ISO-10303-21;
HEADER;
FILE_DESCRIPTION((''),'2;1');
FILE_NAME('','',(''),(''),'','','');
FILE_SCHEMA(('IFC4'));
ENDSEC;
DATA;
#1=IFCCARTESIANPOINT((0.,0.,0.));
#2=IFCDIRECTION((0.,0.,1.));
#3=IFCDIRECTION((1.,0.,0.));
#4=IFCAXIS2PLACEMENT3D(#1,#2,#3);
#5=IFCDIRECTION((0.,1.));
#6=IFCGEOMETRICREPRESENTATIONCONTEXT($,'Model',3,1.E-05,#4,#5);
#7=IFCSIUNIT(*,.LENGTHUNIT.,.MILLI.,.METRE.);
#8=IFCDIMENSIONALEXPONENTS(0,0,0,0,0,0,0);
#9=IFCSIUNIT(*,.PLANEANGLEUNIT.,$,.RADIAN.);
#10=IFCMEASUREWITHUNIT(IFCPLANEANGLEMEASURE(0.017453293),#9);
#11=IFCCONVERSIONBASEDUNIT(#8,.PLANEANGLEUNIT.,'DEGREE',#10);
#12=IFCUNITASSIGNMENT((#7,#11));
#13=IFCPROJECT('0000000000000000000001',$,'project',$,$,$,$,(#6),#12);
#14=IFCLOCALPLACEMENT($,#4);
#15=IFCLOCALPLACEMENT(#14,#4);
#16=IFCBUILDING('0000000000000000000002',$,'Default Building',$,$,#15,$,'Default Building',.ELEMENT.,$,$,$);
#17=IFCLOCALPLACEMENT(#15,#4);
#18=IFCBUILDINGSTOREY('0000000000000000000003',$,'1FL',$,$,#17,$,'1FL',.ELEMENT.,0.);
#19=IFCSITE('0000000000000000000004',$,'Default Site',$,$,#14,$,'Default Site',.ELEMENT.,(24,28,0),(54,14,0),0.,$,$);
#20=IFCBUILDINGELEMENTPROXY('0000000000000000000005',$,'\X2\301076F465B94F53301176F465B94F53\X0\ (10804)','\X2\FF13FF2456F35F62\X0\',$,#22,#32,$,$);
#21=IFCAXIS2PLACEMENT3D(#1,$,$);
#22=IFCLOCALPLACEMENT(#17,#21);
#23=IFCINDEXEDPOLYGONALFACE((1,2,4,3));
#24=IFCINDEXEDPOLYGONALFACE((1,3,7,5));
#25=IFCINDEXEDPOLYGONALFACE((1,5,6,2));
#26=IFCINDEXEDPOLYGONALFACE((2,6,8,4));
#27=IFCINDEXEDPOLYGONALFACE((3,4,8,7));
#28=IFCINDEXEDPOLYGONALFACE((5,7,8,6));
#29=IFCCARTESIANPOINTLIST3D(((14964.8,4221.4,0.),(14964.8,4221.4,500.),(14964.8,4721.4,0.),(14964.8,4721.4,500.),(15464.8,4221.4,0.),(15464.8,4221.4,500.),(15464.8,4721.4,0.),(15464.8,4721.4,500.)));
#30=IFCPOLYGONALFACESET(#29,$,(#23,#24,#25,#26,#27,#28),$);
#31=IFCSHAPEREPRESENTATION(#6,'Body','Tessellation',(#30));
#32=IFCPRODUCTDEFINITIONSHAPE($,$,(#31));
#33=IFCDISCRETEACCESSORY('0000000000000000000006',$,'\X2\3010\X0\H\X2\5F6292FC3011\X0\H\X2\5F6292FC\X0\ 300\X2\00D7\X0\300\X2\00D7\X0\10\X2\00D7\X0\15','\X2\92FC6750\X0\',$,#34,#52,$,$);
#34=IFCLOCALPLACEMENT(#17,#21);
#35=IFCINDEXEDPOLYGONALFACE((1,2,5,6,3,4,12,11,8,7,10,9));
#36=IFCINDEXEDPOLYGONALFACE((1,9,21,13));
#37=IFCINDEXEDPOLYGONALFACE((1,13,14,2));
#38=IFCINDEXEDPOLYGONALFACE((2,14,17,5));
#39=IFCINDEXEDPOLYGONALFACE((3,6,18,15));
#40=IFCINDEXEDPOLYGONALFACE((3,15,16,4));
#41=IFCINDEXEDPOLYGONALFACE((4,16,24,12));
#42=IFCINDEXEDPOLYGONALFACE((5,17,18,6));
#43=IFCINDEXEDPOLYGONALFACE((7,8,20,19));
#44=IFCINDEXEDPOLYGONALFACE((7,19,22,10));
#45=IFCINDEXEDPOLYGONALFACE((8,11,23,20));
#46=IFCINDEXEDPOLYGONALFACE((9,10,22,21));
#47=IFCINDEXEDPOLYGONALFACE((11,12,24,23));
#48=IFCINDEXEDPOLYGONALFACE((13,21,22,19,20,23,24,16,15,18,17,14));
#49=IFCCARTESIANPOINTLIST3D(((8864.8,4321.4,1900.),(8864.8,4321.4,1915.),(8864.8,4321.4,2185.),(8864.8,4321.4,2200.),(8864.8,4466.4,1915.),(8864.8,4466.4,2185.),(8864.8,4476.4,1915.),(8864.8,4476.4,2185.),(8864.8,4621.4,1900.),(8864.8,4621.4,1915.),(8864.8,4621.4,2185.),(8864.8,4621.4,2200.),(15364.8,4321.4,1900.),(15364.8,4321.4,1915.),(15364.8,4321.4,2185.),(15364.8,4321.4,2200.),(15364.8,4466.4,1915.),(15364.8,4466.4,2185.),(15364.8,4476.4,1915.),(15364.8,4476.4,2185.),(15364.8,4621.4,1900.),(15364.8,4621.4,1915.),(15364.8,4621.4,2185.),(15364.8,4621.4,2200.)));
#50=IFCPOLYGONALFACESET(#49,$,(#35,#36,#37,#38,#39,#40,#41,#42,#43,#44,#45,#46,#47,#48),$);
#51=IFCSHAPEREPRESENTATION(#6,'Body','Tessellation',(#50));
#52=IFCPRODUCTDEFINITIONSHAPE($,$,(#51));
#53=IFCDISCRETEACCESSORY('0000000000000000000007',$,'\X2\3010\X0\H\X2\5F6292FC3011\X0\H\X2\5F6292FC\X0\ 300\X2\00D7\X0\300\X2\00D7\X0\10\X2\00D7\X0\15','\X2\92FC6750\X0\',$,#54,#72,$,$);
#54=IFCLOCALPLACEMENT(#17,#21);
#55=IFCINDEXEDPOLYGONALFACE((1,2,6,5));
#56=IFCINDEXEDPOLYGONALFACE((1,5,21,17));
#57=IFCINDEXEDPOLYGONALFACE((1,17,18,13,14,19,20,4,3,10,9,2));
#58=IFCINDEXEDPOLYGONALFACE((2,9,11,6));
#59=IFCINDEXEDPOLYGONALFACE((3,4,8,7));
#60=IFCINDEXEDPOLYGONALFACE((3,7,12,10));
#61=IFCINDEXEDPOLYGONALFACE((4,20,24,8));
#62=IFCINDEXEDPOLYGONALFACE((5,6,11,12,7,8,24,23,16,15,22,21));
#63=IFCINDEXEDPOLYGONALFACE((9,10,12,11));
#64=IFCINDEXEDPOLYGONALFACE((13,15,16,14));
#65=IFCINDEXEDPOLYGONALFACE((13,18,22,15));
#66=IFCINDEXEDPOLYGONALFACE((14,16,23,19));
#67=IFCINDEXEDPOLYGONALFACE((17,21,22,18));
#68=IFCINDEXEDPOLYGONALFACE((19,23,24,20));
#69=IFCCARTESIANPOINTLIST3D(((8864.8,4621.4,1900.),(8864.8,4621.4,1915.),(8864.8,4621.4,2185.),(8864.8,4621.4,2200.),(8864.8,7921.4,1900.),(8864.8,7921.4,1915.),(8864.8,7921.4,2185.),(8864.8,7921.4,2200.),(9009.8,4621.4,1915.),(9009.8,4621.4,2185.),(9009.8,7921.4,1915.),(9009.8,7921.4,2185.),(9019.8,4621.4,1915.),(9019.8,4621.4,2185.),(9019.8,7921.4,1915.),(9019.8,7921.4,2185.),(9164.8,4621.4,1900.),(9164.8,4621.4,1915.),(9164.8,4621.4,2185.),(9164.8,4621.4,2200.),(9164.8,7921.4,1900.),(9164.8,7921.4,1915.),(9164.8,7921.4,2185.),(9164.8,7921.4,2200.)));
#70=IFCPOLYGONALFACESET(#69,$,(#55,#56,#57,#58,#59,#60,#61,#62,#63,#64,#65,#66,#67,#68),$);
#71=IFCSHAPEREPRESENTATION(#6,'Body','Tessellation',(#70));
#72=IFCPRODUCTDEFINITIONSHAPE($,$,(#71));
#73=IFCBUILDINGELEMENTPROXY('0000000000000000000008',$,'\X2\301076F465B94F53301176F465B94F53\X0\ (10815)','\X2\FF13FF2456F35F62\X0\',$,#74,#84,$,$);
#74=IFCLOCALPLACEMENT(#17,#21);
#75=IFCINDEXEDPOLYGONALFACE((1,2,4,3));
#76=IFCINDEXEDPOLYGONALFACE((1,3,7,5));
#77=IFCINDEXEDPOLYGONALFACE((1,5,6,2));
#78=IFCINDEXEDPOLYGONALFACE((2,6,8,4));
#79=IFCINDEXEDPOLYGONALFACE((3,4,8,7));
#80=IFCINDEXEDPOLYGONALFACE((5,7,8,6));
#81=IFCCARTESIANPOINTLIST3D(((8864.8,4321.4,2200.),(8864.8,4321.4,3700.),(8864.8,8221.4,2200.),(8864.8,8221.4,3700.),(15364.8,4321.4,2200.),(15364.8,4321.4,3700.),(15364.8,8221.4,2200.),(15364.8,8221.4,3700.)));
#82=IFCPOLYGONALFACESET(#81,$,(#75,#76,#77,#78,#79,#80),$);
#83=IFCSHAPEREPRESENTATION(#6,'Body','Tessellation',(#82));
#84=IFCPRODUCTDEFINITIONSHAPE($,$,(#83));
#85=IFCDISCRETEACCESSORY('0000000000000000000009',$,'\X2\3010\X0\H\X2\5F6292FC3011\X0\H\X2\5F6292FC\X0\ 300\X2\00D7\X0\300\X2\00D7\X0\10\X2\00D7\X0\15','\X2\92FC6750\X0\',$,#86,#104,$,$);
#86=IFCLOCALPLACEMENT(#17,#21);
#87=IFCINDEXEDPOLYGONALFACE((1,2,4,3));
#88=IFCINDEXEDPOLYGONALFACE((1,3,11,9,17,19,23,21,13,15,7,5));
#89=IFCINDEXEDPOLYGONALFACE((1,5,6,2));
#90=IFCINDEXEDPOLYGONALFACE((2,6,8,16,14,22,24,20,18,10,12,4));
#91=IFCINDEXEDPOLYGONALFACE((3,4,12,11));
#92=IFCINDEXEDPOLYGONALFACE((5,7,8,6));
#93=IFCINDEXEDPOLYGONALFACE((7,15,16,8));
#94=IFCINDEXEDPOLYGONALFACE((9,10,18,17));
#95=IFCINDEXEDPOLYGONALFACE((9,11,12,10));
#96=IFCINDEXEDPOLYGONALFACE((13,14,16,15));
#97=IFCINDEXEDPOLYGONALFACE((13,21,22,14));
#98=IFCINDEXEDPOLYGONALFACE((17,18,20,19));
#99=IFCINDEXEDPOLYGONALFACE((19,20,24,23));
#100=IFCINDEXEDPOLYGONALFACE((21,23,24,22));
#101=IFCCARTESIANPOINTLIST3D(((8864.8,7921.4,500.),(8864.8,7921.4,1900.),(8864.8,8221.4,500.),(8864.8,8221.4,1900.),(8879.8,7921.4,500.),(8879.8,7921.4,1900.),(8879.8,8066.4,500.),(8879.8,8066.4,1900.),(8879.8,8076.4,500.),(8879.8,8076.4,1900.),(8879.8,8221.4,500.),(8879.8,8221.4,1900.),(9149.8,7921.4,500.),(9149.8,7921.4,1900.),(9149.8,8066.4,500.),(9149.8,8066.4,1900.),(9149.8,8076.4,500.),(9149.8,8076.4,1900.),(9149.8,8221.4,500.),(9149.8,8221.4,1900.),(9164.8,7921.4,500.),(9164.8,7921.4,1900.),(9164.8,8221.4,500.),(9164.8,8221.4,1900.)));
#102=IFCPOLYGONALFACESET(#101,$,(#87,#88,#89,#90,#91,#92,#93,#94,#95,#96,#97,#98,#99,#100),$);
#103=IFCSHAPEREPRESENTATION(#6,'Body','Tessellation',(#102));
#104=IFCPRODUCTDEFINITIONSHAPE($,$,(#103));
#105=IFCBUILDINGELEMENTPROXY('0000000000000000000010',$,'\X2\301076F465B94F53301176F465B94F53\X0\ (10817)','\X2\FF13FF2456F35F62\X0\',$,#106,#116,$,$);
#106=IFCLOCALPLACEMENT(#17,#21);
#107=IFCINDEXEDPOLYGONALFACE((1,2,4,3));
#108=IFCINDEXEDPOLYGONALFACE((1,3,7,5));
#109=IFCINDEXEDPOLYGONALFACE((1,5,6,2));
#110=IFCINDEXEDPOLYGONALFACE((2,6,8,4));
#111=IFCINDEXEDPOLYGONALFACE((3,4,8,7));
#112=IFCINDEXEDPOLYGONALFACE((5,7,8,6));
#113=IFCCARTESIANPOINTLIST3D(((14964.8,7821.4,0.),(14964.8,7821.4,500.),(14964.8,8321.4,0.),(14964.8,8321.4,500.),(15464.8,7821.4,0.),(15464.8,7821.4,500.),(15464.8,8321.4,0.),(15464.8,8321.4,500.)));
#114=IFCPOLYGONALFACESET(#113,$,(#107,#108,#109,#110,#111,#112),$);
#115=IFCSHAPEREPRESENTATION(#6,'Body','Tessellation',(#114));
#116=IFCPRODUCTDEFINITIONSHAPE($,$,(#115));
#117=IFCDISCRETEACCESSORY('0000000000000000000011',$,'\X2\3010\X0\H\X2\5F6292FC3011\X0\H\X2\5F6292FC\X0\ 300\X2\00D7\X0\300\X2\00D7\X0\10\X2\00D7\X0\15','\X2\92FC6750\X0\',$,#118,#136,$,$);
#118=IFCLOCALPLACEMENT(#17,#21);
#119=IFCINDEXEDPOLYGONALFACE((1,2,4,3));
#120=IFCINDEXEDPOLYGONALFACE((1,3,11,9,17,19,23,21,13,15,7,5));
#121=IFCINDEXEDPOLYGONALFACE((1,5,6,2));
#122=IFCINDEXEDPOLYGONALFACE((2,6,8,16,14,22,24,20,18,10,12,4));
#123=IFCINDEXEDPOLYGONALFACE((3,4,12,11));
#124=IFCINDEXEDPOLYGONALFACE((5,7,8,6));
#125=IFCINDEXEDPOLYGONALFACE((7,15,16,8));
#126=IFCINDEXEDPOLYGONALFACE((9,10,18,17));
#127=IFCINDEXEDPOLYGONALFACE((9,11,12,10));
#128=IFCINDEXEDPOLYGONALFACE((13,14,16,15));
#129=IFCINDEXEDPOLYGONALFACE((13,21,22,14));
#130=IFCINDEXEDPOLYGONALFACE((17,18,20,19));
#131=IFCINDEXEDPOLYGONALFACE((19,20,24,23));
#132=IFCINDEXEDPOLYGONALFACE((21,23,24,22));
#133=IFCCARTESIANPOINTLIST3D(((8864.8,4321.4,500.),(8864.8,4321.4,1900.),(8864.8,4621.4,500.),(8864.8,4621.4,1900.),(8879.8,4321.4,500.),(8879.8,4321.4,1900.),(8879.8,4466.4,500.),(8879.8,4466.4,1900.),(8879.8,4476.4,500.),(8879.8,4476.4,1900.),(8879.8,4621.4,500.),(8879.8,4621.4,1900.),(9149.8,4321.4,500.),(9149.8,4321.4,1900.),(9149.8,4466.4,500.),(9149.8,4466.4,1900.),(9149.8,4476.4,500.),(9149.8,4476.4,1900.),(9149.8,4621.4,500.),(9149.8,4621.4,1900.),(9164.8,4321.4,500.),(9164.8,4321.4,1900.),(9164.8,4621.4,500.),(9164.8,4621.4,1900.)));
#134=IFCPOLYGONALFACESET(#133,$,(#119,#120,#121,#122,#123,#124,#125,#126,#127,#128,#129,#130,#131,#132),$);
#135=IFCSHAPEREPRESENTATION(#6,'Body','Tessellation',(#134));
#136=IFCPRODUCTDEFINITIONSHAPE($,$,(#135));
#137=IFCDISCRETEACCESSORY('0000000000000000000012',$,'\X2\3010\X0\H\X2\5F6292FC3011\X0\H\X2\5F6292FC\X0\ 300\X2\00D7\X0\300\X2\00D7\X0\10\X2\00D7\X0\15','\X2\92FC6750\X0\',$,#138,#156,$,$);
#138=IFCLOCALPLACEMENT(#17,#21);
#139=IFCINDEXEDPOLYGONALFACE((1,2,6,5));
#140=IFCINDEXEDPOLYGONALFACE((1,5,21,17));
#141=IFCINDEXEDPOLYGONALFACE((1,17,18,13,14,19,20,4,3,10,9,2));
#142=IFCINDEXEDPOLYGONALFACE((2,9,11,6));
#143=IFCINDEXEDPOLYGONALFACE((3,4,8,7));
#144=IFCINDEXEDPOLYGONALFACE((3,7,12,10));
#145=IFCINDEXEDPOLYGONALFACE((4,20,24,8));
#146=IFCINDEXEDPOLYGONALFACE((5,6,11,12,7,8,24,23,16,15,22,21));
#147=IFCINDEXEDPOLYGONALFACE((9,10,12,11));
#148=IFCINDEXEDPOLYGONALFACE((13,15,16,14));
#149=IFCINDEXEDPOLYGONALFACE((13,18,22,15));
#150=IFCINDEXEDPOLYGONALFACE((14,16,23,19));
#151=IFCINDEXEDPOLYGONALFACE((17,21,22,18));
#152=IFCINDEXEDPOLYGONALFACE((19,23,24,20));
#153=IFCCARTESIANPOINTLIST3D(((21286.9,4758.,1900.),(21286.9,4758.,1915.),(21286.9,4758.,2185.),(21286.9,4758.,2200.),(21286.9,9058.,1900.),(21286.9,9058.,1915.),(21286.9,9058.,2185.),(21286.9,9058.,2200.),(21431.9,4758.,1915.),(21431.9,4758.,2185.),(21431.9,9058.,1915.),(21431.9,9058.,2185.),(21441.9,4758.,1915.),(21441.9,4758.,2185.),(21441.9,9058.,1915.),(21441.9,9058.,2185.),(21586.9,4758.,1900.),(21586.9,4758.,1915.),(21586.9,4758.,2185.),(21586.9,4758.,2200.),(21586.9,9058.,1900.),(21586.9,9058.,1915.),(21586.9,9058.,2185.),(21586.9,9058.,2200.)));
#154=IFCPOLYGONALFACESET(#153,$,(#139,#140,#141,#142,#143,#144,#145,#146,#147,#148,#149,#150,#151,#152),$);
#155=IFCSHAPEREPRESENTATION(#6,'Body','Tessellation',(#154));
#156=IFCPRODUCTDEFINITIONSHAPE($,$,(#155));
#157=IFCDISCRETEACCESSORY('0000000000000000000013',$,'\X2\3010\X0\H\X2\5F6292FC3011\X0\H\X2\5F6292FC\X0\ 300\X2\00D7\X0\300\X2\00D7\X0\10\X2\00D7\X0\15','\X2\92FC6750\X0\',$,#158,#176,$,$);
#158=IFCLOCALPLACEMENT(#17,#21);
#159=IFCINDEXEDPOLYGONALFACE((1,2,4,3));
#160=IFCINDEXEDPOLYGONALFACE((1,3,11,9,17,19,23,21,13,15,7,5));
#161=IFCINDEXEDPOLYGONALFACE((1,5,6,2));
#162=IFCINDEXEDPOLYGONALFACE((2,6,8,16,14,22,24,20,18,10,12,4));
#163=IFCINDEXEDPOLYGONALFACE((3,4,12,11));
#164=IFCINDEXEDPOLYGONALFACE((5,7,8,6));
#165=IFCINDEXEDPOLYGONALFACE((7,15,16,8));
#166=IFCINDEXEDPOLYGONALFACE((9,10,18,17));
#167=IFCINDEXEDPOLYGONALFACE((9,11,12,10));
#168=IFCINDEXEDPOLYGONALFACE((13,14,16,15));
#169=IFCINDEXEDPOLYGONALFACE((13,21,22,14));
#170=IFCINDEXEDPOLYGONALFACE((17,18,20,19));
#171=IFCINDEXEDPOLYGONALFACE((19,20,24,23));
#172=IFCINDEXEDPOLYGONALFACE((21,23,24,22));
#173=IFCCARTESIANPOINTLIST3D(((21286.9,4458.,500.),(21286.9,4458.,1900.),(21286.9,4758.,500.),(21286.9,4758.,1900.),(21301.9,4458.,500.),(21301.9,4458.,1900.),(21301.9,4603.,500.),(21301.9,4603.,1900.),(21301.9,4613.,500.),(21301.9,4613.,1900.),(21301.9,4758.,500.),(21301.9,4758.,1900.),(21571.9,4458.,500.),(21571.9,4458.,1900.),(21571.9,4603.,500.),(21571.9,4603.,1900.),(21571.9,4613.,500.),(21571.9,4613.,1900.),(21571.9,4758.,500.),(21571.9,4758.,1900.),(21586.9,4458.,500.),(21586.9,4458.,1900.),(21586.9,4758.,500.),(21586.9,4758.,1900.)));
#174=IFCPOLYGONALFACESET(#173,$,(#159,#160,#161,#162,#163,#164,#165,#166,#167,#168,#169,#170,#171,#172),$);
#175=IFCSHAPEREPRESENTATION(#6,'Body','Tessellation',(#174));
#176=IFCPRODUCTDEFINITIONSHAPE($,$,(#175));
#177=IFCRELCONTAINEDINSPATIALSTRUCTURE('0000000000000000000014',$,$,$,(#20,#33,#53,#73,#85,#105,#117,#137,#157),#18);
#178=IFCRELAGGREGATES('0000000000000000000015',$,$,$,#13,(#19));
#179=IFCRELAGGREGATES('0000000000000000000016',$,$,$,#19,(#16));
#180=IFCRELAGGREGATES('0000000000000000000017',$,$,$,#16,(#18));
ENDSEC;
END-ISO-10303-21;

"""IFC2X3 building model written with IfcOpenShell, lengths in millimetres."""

from ifc_helpers import new_model, entity, si_unit, converted_unit, direction, frame, origin_with_axes, origin_2d_with_axis, place, context, project, spatial, rectangle, i_section, extrude, source, transform, mapped, element, save


model = new_model("IFC2X3")

# Units and contexts
model_context = context("Model", 3, precision=1e-05, world=origin_with_axes(), true_north=direction((0.0, 1.0)))
ifc_project = project(units=[si_unit("LENGTHUNIT", "METRE", prefix="MILLI"), converted_unit("PLANEANGLEUNIT", "DEGREE", entity("IfcPlaneAngleMeasure", 0.017453293), si_unit("PLANEANGLEUNIT", "RADIAN"), dimensions=[0, 0, 0, 0, 0, 0, 0])], contexts=[model_context])

# Site, building, storey
site_placement = place(None, origin_with_axes())
site = spatial("IfcSite", under=ifc_project, at=site_placement, Name="Default Site", LongName="Default Site", CompositionType="ELEMENT", RefLatitude=(24, 28, 0), RefLongitude=(54, 14, 0), RefElevation=0.0)
building_placement = place(site_placement, origin_with_axes())
building = spatial("IfcBuilding", under=site, at=building_placement, Name="Default Building", LongName="Default Building", CompositionType="ELEMENT")
storey_placement = place(building_placement, origin_with_axes())
storey = spatial("IfcBuildingStorey", under=building, at=storey_placement, Name="1FL", LongName="1FL", CompositionType="ELEMENT", Elevation=0.0)

# Building element proxy
shared_shape_1 = source(origin_with_axes(), model_context, "Body", "SweptSolid", [
    extrude(rectangle(XDim=500.0, YDim=500.0, at=origin_2d_with_axis()), origin_with_axes(), (0.0, 0.0, 1.0), 500.0),
])
proxy_1_placement = place(storey_placement, frame((15214.8, 4471.4, 0.0), z_axis=(0.0, 0.0, 1.0), x_axis=(1.0, 0.0, 0.0)))
element("IfcBuildingElementProxy", 1, at=proxy_1_placement, inside=storey, Name="【直方体】直方体 (10804)", Description="３Ｄ図形", context=model_context, shape_type="MappedRepresentation", body=[
    mapped(shared_shape_1, transform((0.0, 0.0, 0.0))),
])

# Discrete accessories
shared_shape_2 = source(origin_with_axes(), model_context, "Body", "SweptSolid", [
    extrude(i_section(OverallWidth=300.0, OverallDepth=300.0, WebThickness=10.0, FlangeThickness=15.0, at=origin_2d_with_axis()), frame((3250.0, 0.0, -150.0), z_axis=(-1.0, 0.0, 0.0), x_axis=(0.0, -1.0, 0.0)), (0.0, 0.0, 1.0), 6500.0),
])
discrete_accessory_1_placement = place(storey_placement, frame((12114.8, 4471.4, 2200.0), z_axis=(0.0, 0.0, 1.0), x_axis=(1.0, 0.0, 0.0)))
element("IfcDiscreteAccessory", 2, at=discrete_accessory_1_placement, inside=storey, Name="【H形鋼】H形鋼 300×300×10×15", Description="鋼材", context=model_context, shape_type="MappedRepresentation", body=[
    mapped(shared_shape_2, transform((0.0, 0.0, 0.0))),
])
shared_shape_3 = source(origin_with_axes(), model_context, "Body", "SweptSolid", [
    extrude(i_section(OverallWidth=300.0, OverallDepth=300.0, WebThickness=10.0, FlangeThickness=15.0, at=origin_2d_with_axis()), frame((1650.0, 0.0, -150.0), z_axis=(-1.0, 0.0, 0.0), x_axis=(0.0, -1.0, 0.0)), (0.0, 0.0, 1.0), 3300.0),
])
discrete_accessory_2_placement = place(storey_placement, frame((9014.8, 6271.4, 2200.0), z_axis=(0.0, 0.0, 1.0), x_axis=(0.0, -1.0, 0.0)))
element("IfcDiscreteAccessory", 3, at=discrete_accessory_2_placement, inside=storey, Name="【H形鋼】H形鋼 300×300×10×15", Description="鋼材", context=model_context, shape_type="MappedRepresentation", body=[
    mapped(shared_shape_3, transform((0.0, 0.0, 0.0))),
])

# Building element proxy
shared_shape_4 = source(origin_with_axes(), model_context, "Body", "SweptSolid", [
    extrude(rectangle(XDim=6500.0, YDim=3900.0, at=origin_2d_with_axis()), origin_with_axes(), (0.0, 0.0, 1.0), 1500.0),
])
proxy_2_placement = place(storey_placement, frame((12114.8, 6271.4, 2200.0), z_axis=(0.0, 0.0, 1.0), x_axis=(1.0, 0.0, 0.0)))
element("IfcBuildingElementProxy", 4, at=proxy_2_placement, inside=storey, Name="【直方体】直方体 (10815)", Description="３Ｄ図形", context=model_context, shape_type="MappedRepresentation", body=[
    mapped(shared_shape_4, transform((0.0, 0.0, 0.0))),
])

# Discrete accessory
shared_shape_5 = source(origin_with_axes(), model_context, "Body", "SweptSolid", [
    extrude(i_section(OverallWidth=300.0, OverallDepth=300.0, WebThickness=10.0, FlangeThickness=15.0, at=origin_2d_with_axis()), frame((700.0, 0.0, -150.0), z_axis=(-1.0, 0.0, 0.0), x_axis=(0.0, -1.0, 0.0)), (0.0, 0.0, 1.0), 1400.0),
])
discrete_accessory_3_placement = place(storey_placement, frame((8864.8, 8071.4, 1200.0), z_axis=(-1.0, 0.0, 0.0), x_axis=(0.0, 0.0, 1.0)))
element("IfcDiscreteAccessory", 5, at=discrete_accessory_3_placement, inside=storey, Name="【H形鋼】H形鋼 300×300×10×15", Description="鋼材", context=model_context, shape_type="MappedRepresentation", body=[
    mapped(shared_shape_5, transform((0.0, 0.0, 0.0))),
])

# Building element proxy
shared_shape_6 = source(origin_with_axes(), model_context, "Body", "SweptSolid", [
    extrude(rectangle(XDim=500.0, YDim=500.0, at=origin_2d_with_axis()), origin_with_axes(), (0.0, 0.0, 1.0), 500.0),
])
proxy_3_placement = place(storey_placement, frame((15214.8, 8071.4, 0.0), z_axis=(0.0, 0.0, 1.0), x_axis=(1.0, 0.0, 0.0)))
element("IfcBuildingElementProxy", 6, at=proxy_3_placement, inside=storey, Name="【直方体】直方体 (10817)", Description="３Ｄ図形", context=model_context, shape_type="MappedRepresentation", body=[
    mapped(shared_shape_6, transform((0.0, 0.0, 0.0))),
])

# Discrete accessories
shared_shape_7 = source(origin_with_axes(), model_context, "Body", "SweptSolid", [
    extrude(i_section(OverallWidth=300.0, OverallDepth=300.0, WebThickness=10.0, FlangeThickness=15.0, at=origin_2d_with_axis()), frame((700.0, 0.0, -150.0), z_axis=(-1.0, 0.0, 0.0), x_axis=(0.0, -1.0, 0.0)), (0.0, 0.0, 1.0), 1400.0),
])
discrete_accessory_4_placement = place(storey_placement, frame((8864.8, 4471.4, 1200.0), z_axis=(-1.0, 0.0, 0.0), x_axis=(0.0, 0.0, 1.0)))
element("IfcDiscreteAccessory", 7, at=discrete_accessory_4_placement, inside=storey, Name="【H形鋼】H形鋼 300×300×10×15", Description="鋼材", context=model_context, shape_type="MappedRepresentation", body=[
    mapped(shared_shape_7, transform((0.0, 0.0, 0.0))),
])
shared_shape_8 = source(origin_with_axes(), model_context, "Body", "SweptSolid", [
    extrude(i_section(OverallWidth=300.0, OverallDepth=300.0, WebThickness=10.0, FlangeThickness=15.0, at=origin_2d_with_axis()), frame((2150.0, 0.0, -150.0), z_axis=(-1.0, 0.0, 0.0), x_axis=(0.0, -1.0, 0.0)), (0.0, 0.0, 1.0), 4300.0),
])
discrete_accessory_5_placement = place(storey_placement, frame((21436.9, 6908.0, 2200.0), z_axis=(0.0, 0.0, 1.0), x_axis=(0.0, -1.0, 0.0)))
element("IfcDiscreteAccessory", 8, at=discrete_accessory_5_placement, inside=storey, Name="【H形鋼】H形鋼 300×300×10×15", Description="鋼材", context=model_context, shape_type="MappedRepresentation", body=[
    mapped(shared_shape_8, transform((0.0, 0.0, 0.0))),
])
shared_shape_9 = source(origin_with_axes(), model_context, "Body", "SweptSolid", [
    extrude(i_section(OverallWidth=300.0, OverallDepth=300.0, WebThickness=10.0, FlangeThickness=15.0, at=origin_2d_with_axis()), frame((700.0, 0.0, -150.0), z_axis=(-1.0, 0.0, 0.0), x_axis=(0.0, -1.0, 0.0)), (0.0, 0.0, 1.0), 1400.0),
])
discrete_accessory_6_placement = place(storey_placement, frame((21286.9, 4608.0, 1200.0), z_axis=(-1.0, 0.0, 0.0), x_axis=(0.0, 0.0, 1.0)))
element("IfcDiscreteAccessory", 9, at=discrete_accessory_6_placement, inside=storey, Name="【H形鋼】H形鋼 300×300×10×15", Description="鋼材", context=model_context, shape_type="MappedRepresentation", body=[
    mapped(shared_shape_9, transform((0.0, 0.0, 0.0))),
])

save(model, "model.ifc")
